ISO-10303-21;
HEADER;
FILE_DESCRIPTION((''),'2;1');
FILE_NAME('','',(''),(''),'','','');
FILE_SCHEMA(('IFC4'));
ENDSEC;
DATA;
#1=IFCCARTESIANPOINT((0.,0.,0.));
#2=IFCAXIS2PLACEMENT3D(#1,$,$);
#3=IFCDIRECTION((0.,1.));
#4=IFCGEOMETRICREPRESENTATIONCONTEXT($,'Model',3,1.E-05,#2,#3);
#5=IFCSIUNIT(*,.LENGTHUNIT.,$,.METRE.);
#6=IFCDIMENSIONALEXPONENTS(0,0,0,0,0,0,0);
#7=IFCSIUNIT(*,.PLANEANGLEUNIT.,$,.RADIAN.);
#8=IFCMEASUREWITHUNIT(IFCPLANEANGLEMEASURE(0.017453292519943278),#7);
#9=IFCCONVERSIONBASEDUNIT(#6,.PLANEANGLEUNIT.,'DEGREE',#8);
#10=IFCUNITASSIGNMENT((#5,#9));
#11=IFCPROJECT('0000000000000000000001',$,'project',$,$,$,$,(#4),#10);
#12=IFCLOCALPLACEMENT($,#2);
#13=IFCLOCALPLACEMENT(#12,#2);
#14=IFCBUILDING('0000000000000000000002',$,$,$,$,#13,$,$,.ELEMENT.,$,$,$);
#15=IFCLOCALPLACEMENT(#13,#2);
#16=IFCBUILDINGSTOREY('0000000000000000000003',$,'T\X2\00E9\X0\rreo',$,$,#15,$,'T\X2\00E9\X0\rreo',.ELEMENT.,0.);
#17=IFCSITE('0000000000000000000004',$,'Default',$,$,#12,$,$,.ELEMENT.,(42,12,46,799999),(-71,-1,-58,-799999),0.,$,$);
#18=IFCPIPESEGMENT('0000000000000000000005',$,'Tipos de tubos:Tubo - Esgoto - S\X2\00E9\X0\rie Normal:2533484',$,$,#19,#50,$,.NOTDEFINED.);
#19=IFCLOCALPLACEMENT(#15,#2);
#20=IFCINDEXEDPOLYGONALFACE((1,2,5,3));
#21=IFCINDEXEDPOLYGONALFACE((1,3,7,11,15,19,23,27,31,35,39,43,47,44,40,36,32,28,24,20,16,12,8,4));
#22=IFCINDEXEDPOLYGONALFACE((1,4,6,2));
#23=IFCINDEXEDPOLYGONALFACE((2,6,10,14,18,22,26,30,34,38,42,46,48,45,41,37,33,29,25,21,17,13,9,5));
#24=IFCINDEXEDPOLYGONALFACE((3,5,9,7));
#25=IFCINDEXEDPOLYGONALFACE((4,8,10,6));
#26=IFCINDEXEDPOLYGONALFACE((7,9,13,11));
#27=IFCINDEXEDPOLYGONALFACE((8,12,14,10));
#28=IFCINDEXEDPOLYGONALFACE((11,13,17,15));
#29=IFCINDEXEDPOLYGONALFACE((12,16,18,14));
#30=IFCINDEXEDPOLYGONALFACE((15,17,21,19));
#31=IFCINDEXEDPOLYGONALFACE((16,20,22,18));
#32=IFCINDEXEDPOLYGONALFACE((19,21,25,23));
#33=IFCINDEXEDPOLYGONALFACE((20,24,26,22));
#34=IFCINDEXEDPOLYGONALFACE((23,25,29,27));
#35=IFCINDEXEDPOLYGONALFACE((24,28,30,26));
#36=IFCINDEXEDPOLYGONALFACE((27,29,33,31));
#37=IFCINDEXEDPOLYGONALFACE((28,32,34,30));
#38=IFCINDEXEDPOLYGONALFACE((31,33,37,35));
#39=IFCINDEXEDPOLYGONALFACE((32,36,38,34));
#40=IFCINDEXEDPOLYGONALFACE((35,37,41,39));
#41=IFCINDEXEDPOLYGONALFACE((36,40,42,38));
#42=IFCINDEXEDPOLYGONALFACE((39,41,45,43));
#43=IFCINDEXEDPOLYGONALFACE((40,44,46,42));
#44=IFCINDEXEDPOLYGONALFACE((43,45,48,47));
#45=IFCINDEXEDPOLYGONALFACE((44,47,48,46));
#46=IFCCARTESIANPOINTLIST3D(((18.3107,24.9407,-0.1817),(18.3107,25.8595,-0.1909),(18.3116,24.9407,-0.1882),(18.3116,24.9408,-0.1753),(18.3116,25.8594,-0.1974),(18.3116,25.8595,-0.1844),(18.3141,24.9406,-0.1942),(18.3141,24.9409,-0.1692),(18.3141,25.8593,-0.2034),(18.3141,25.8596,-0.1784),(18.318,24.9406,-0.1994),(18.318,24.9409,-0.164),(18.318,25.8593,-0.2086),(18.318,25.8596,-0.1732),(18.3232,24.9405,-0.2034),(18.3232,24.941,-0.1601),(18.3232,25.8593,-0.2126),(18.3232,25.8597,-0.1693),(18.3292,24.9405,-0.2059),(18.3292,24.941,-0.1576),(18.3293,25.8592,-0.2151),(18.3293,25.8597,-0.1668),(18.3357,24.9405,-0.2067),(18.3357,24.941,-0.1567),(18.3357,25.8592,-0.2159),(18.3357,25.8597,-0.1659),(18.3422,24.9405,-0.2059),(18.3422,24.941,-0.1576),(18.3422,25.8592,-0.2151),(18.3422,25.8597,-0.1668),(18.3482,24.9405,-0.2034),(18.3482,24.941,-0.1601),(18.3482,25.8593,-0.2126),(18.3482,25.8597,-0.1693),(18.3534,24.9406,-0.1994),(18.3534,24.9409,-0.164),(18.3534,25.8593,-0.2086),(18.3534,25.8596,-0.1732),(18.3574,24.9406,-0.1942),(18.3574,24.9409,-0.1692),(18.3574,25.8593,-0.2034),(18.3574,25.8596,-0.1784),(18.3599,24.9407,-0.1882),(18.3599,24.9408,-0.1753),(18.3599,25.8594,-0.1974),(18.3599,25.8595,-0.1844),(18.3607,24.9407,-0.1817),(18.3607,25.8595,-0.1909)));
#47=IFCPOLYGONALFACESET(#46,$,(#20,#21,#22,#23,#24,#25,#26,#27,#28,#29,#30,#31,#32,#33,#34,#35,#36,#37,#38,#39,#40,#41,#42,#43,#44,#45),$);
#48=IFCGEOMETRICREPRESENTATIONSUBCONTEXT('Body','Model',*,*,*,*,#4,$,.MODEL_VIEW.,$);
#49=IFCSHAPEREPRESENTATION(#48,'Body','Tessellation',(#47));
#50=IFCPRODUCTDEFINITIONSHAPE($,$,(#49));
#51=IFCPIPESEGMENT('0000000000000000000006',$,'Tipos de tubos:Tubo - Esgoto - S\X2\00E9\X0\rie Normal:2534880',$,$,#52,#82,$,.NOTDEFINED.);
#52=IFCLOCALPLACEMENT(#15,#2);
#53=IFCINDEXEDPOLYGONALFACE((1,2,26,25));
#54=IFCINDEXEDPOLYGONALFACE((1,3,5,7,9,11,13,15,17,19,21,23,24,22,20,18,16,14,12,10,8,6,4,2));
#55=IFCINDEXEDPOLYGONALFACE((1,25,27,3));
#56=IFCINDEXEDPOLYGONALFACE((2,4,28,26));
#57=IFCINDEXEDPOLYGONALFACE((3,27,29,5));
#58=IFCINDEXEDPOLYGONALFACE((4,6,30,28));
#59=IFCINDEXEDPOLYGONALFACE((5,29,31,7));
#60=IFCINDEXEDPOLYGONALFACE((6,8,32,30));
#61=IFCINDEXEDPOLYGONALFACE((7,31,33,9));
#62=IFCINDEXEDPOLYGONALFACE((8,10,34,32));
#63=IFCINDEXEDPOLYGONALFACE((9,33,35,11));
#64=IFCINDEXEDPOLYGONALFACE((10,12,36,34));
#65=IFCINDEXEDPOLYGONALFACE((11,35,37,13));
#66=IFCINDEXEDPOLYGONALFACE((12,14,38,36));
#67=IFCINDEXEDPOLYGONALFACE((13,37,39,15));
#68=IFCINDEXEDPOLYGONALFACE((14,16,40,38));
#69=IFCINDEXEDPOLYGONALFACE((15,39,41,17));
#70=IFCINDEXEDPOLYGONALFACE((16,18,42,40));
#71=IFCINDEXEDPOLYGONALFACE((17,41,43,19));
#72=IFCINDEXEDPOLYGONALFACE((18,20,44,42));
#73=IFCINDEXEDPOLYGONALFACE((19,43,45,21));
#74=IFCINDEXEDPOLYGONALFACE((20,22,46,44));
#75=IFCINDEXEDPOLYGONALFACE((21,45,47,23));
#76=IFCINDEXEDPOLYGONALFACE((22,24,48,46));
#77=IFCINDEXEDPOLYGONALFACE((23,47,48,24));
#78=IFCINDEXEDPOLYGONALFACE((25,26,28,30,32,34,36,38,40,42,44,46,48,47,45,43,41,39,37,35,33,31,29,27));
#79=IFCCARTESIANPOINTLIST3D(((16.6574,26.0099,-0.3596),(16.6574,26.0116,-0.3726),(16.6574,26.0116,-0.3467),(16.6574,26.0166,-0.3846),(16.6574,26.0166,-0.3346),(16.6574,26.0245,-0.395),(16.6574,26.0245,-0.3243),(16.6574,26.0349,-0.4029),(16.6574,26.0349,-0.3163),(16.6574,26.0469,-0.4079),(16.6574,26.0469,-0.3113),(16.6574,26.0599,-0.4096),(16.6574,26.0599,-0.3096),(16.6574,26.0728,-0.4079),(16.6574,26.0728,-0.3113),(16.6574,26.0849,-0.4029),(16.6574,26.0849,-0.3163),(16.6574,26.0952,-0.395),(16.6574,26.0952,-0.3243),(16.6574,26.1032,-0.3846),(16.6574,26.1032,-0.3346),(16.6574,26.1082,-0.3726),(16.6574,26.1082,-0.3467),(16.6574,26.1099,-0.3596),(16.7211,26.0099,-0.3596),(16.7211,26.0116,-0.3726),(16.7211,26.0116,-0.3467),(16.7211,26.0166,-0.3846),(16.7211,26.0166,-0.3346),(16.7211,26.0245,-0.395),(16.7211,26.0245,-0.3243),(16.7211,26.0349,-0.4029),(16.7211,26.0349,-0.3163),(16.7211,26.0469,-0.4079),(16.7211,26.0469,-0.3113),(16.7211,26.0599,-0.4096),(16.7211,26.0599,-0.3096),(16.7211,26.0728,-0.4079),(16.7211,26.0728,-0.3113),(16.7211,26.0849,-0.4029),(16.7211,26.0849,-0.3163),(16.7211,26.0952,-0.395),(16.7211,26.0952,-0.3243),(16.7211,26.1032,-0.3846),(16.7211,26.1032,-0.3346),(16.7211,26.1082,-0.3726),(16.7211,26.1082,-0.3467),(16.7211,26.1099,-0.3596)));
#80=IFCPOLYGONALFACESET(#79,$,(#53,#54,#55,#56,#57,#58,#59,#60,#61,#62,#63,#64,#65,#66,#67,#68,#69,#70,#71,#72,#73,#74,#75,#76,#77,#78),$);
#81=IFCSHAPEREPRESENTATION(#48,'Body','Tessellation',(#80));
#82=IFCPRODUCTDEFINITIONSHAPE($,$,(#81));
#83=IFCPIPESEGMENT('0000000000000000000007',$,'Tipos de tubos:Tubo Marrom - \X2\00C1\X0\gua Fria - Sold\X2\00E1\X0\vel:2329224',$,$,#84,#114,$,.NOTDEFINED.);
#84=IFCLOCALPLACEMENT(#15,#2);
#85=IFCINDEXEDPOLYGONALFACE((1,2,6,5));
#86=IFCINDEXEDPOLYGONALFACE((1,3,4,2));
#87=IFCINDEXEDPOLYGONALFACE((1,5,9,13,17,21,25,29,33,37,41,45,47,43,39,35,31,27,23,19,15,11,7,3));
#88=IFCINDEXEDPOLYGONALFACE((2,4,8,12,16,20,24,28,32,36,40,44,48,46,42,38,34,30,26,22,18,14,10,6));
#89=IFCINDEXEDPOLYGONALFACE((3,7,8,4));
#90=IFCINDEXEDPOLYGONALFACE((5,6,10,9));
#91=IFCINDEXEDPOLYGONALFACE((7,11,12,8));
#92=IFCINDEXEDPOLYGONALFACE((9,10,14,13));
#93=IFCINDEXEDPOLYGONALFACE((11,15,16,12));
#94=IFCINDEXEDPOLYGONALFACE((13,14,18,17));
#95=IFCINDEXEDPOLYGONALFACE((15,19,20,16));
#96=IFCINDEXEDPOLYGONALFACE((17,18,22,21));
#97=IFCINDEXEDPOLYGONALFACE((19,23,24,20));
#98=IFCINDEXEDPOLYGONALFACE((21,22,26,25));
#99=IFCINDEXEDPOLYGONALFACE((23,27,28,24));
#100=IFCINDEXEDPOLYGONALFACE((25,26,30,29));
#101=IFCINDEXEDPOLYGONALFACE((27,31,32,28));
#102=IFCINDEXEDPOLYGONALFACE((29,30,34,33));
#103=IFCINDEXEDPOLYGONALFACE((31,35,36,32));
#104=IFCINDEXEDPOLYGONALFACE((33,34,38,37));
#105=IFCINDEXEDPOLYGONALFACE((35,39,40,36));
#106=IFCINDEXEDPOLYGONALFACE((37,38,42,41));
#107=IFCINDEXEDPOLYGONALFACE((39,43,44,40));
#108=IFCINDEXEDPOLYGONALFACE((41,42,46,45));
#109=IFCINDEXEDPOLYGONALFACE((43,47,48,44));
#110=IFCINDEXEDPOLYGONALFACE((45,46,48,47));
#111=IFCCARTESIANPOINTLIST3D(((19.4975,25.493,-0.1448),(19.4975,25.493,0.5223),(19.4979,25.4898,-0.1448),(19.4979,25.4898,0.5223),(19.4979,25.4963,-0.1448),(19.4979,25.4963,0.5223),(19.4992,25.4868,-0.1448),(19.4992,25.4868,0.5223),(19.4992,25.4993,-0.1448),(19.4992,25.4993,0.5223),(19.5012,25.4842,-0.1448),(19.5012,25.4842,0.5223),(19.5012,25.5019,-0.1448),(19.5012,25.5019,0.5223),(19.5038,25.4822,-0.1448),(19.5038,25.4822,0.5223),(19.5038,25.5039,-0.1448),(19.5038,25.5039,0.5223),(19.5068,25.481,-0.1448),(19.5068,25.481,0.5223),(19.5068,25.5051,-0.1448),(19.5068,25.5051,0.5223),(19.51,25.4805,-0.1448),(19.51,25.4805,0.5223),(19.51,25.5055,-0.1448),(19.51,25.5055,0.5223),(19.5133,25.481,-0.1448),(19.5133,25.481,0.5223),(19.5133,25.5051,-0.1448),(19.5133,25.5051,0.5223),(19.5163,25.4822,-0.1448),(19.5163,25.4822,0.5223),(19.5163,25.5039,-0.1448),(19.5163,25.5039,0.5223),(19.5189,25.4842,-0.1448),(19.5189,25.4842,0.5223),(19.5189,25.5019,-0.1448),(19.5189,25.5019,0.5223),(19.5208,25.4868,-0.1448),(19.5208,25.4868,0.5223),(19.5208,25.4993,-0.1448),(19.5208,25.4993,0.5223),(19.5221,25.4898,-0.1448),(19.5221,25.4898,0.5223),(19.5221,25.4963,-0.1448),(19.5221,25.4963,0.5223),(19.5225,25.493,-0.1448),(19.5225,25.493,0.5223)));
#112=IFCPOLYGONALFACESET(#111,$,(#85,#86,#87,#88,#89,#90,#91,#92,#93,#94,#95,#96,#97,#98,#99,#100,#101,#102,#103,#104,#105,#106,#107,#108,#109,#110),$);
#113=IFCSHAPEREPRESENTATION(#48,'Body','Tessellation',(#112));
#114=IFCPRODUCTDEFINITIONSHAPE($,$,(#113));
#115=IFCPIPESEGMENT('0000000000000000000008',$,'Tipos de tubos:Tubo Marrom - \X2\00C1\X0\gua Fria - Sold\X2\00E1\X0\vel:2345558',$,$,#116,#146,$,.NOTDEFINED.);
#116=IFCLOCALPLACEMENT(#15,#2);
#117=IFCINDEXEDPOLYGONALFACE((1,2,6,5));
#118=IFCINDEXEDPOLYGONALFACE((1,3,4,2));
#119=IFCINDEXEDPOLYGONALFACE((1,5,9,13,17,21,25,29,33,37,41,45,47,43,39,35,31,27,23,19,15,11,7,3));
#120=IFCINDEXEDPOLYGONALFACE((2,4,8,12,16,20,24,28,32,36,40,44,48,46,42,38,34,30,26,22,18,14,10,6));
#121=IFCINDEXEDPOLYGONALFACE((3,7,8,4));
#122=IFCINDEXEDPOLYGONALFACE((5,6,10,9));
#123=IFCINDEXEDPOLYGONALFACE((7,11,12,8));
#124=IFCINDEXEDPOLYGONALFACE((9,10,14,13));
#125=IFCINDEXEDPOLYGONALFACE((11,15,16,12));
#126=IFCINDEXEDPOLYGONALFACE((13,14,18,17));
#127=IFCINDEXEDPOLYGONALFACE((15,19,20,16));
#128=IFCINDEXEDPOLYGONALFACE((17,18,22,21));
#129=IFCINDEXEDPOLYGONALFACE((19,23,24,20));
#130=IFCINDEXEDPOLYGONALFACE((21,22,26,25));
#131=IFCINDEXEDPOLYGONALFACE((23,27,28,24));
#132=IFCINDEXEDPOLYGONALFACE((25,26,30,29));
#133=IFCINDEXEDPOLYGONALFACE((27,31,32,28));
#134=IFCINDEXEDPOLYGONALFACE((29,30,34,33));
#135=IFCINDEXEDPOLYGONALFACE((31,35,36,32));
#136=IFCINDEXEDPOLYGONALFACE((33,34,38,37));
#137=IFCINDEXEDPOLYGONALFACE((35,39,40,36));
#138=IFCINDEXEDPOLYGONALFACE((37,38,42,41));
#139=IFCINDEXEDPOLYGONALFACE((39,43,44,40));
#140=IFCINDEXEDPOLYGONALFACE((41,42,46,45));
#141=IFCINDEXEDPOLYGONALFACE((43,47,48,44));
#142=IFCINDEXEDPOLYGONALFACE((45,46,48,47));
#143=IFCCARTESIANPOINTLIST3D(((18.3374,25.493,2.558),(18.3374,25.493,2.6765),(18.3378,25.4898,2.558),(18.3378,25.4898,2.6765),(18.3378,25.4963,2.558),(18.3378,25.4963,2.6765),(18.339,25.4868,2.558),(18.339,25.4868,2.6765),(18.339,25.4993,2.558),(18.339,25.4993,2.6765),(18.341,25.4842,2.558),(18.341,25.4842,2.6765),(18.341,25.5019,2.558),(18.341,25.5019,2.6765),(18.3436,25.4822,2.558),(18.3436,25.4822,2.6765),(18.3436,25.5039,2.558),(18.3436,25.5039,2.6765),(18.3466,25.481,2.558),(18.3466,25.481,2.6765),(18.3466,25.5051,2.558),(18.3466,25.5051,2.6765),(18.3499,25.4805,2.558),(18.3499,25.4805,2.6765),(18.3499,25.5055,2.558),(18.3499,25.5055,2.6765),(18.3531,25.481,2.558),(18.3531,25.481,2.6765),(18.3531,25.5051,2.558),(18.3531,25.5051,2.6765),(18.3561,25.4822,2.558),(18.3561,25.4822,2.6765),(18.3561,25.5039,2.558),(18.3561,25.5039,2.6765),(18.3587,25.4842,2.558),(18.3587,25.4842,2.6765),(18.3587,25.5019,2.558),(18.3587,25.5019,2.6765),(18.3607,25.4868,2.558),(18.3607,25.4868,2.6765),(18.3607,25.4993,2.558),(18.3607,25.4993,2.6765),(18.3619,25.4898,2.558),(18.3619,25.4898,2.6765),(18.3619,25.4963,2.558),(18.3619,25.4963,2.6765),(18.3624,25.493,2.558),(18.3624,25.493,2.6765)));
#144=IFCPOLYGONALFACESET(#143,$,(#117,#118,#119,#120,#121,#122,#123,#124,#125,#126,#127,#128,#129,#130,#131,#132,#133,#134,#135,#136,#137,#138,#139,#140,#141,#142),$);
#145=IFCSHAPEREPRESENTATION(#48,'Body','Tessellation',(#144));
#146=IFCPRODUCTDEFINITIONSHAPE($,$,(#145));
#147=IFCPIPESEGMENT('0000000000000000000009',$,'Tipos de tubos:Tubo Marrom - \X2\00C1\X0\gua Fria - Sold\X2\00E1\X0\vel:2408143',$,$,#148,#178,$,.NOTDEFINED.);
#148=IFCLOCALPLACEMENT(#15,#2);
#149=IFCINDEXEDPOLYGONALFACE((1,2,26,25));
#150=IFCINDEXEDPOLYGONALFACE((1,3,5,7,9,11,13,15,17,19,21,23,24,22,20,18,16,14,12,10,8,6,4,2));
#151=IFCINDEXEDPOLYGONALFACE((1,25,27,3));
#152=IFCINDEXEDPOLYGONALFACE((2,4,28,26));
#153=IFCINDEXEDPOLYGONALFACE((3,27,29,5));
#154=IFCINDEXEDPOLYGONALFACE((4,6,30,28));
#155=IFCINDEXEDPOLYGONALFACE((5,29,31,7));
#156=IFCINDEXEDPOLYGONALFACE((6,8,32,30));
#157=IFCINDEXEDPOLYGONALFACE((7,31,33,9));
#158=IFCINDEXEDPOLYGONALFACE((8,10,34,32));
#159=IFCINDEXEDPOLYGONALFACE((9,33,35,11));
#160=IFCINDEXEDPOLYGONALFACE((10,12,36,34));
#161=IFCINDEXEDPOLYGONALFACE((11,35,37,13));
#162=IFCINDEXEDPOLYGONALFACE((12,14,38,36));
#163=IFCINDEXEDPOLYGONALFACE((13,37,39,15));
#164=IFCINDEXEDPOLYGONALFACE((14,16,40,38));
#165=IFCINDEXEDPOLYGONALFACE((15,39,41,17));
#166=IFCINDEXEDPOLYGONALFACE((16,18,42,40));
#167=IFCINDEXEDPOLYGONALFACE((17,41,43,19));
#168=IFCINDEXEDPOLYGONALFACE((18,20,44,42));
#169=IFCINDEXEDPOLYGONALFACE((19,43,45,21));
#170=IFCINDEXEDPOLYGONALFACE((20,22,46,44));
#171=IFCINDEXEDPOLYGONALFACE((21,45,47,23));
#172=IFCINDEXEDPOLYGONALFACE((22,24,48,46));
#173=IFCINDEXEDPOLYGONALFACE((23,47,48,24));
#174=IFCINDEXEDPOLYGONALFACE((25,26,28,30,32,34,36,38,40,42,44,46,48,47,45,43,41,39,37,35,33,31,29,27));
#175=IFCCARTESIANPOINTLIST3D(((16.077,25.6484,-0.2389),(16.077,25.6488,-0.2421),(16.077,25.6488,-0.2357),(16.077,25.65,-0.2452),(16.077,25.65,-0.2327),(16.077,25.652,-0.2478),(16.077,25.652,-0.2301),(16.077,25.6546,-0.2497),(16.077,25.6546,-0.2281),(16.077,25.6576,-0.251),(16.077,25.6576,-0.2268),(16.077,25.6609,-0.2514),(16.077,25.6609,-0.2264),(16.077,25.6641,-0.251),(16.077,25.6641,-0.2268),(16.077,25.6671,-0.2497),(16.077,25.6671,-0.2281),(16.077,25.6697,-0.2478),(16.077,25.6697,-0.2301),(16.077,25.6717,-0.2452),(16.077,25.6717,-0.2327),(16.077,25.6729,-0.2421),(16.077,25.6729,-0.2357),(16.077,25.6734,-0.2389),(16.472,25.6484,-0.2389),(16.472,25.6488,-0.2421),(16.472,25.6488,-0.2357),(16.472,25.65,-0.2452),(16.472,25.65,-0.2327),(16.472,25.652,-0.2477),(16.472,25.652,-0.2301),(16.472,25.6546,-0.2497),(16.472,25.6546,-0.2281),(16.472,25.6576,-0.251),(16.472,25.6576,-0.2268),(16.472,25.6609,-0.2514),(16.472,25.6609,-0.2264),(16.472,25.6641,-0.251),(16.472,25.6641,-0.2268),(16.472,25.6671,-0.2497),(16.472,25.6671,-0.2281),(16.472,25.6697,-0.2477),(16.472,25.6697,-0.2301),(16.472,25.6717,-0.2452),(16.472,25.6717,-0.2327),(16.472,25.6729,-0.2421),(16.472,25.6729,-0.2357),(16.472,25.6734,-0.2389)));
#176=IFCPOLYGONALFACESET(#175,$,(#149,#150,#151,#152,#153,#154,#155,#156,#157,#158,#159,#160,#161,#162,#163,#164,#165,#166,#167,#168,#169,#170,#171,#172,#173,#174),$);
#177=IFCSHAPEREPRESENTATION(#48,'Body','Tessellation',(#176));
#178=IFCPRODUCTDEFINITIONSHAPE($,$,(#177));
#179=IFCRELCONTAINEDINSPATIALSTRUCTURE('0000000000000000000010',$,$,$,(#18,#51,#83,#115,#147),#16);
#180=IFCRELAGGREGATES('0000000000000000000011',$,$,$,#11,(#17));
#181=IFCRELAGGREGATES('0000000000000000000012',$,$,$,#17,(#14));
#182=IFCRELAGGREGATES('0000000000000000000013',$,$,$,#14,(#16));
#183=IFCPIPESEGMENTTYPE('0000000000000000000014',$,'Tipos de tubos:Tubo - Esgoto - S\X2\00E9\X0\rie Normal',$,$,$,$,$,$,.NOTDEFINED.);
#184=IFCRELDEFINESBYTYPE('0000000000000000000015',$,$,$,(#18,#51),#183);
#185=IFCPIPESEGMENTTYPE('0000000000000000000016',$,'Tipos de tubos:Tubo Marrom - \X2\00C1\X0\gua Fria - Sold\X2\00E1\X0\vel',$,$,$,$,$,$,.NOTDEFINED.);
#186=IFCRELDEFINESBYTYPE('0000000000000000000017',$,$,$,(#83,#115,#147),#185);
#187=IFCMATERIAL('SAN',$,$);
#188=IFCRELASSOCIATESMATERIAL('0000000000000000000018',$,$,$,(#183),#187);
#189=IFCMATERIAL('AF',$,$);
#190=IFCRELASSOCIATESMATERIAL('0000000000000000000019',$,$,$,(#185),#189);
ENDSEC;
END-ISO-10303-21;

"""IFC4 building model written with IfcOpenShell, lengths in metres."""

from ifc_helpers import new_model, entity, si_unit, converted_unit, direction, frame, origin, place, context, subcontext, project, spatial, arc, indexed_curve, outline, extrude, material, type_object, element, save


model = new_model("IFC4")

# Units and contexts
model_context = context("Model", 3, precision=1e-05, world=origin(), true_north=direction((0.0, 1.0)))
body_context = subcontext(model_context, "Body", "Model", "MODEL_VIEW")
ifc_project = project(units=[si_unit("LENGTHUNIT", "METRE"), converted_unit("PLANEANGLEUNIT", "DEGREE", entity("IfcPlaneAngleMeasure", 0.017453292519943278), si_unit("PLANEANGLEUNIT", "RADIAN"), dimensions=[0, 0, 0, 0, 0, 0, 0])], contexts=[model_context])

# Site, building, storey
site_placement = place(None, origin())
site = spatial("IfcSite", under=ifc_project, at=site_placement, Name="Default", CompositionType="ELEMENT", RefLatitude=(42, 12, 46, 799999), RefLongitude=(-71, -1, -58, -799999), RefElevation=0.0)
building_placement = place(site_placement, origin())
building = spatial("IfcBuilding", under=site, at=building_placement, CompositionType="ELEMENT")
storey_placement = place(building_placement, origin())
storey = spatial("IfcBuildingStorey", under=building, at=storey_placement, Name="Térreo", LongName="Térreo", CompositionType="ELEMENT", Elevation=0.0)

# Pipe segments
ifc_material_1 = material(Name="SAN")
pipe_segment_type_1 = type_object("IfcPipeSegmentType", Name="Tipos de tubos:Tubo - Esgoto - Série Normal", PredefinedType="NOTDEFINED", material=ifc_material_1)
pipe_segment_1_placement = place(storey_placement, origin())
element("IfcPipeSegment", 1, at=pipe_segment_1_placement, inside=storey, type_object=pipe_segment_type_1, Name="Tipos de tubos:Tubo - Esgoto - Série Normal:2533484", PredefinedType="NOTDEFINED", context=body_context, shape_type="SweptSolid", body=[
    extrude(outline(indexed_curve([(0.025, 0.0), (0.0177, 0.0177), (0.0, 0.025), (-0.0177, 0.0177), (-0.025, 0.0), (-0.0177, -0.0177), (0.0, -0.025), (0.0177, -0.0177)], segments=[arc(1, 2, 3), arc(3, 4, 5), arc(5, 6, 7), arc(7, 8, 1)], self_intersect=False)), frame((18.3357, 25.8595, -0.1909), z_axis=(0.0, -0.99995, 0.01), x_axis=(-1.0, 0.0, 0.0)), (0.0, 0.0, 1.0), 0.9188),
])
pipe_segment_2_placement = place(storey_placement, origin())
element("IfcPipeSegment", 2, at=pipe_segment_2_placement, inside=storey, type_object=pipe_segment_type_1, Name="Tipos de tubos:Tubo - Esgoto - Série Normal:2534880", PredefinedType="NOTDEFINED", context=body_context, shape_type="SweptSolid", body=[
    extrude(outline(indexed_curve([(0.05, 0.0), (0.0354, 0.0354), (0.0, 0.05), (-0.0354, 0.0354), (-0.05, 0.0), (-0.0354, -0.0354), (0.0, -0.05), (0.0354, -0.0354)], segments=[arc(1, 2, 3), arc(3, 4, 5), arc(5, 6, 7), arc(7, 8, 1)], self_intersect=False)), frame((16.6574, 26.0599, -0.3596), z_axis=(1.0, 0.0, 0.0), x_axis=(0.0, -1.0, 0.0)), (0.0, 0.0, 1.0), 0.0636),
])
ifc_material_2 = material(Name="AF")
pipe_segment_type_2 = type_object("IfcPipeSegmentType", Name="Tipos de tubos:Tubo Marrom - Água Fria - Soldável", PredefinedType="NOTDEFINED", material=ifc_material_2)
pipe_segment_3_placement = place(storey_placement, origin())
element("IfcPipeSegment", 3, at=pipe_segment_3_placement, inside=storey, type_object=pipe_segment_type_2, Name="Tipos de tubos:Tubo Marrom - Água Fria - Soldável:2329224", PredefinedType="NOTDEFINED", context=body_context, shape_type="SweptSolid", body=[
    extrude(outline(indexed_curve([(0.0125, 0.0), (0.0088, 0.0088), (0.0, 0.0125), (-0.0088, 0.0088), (-0.0125, 0.0), (-0.0088, -0.0088), (0.0, -0.0125), (0.0088, -0.0088)], segments=[arc(1, 2, 3), arc(3, 4, 5), arc(5, 6, 7), arc(7, 8, 1)], self_intersect=False)), frame((19.51, 25.493, -0.1448), z_axis=(0.0, 0.0, 1.0), x_axis=(-1.0, 0.0, 0.0)), (0.0, 0.0, 1.0), 0.6671),
])
pipe_segment_4_placement = place(storey_placement, origin())
element("IfcPipeSegment", 4, at=pipe_segment_4_placement, inside=storey, type_object=pipe_segment_type_2, Name="Tipos de tubos:Tubo Marrom - Água Fria - Soldável:2345558", PredefinedType="NOTDEFINED", context=body_context, shape_type="SweptSolid", body=[
    extrude(outline(indexed_curve([(0.0125, 0.0), (0.0088, 0.0088), (0.0, 0.0125), (-0.0088, 0.0088), (-0.0125, 0.0), (-0.0088, -0.0088), (0.0, -0.0125), (0.0088, -0.0088)], segments=[arc(1, 2, 3), arc(3, 4, 5), arc(5, 6, 7), arc(7, 8, 1)], self_intersect=False)), frame((18.3499, 25.493, 2.558), z_axis=(0.0, 0.0, 1.0), x_axis=(-1.0, 0.0, 0.0)), (0.0, 0.0, 1.0), 0.1185),
])
pipe_segment_5_placement = place(storey_placement, origin())
element("IfcPipeSegment", 5, at=pipe_segment_5_placement, inside=storey, type_object=pipe_segment_type_2, Name="Tipos de tubos:Tubo Marrom - Água Fria - Soldável:2408143", PredefinedType="NOTDEFINED", context=body_context, shape_type="SweptSolid", body=[
    extrude(outline(indexed_curve([(0.0125, 0.0), (0.0088, 0.0088), (0.0, 0.0125), (-0.0088, 0.0088), (-0.0125, 0.0), (-0.0088, -0.0088), (0.0, -0.0125), (0.0088, -0.0088)], segments=[arc(1, 2, 3), arc(3, 4, 5), arc(5, 6, 7), arc(7, 8, 1)], self_intersect=False)), frame((16.077, 25.6609, -0.2389), z_axis=(1.0, 0.0, 0.00003), x_axis=(0.0, 1.0, 0.0)), (0.0, 0.0, 1.0), 0.395),
])

save(model, "model.ifc")
